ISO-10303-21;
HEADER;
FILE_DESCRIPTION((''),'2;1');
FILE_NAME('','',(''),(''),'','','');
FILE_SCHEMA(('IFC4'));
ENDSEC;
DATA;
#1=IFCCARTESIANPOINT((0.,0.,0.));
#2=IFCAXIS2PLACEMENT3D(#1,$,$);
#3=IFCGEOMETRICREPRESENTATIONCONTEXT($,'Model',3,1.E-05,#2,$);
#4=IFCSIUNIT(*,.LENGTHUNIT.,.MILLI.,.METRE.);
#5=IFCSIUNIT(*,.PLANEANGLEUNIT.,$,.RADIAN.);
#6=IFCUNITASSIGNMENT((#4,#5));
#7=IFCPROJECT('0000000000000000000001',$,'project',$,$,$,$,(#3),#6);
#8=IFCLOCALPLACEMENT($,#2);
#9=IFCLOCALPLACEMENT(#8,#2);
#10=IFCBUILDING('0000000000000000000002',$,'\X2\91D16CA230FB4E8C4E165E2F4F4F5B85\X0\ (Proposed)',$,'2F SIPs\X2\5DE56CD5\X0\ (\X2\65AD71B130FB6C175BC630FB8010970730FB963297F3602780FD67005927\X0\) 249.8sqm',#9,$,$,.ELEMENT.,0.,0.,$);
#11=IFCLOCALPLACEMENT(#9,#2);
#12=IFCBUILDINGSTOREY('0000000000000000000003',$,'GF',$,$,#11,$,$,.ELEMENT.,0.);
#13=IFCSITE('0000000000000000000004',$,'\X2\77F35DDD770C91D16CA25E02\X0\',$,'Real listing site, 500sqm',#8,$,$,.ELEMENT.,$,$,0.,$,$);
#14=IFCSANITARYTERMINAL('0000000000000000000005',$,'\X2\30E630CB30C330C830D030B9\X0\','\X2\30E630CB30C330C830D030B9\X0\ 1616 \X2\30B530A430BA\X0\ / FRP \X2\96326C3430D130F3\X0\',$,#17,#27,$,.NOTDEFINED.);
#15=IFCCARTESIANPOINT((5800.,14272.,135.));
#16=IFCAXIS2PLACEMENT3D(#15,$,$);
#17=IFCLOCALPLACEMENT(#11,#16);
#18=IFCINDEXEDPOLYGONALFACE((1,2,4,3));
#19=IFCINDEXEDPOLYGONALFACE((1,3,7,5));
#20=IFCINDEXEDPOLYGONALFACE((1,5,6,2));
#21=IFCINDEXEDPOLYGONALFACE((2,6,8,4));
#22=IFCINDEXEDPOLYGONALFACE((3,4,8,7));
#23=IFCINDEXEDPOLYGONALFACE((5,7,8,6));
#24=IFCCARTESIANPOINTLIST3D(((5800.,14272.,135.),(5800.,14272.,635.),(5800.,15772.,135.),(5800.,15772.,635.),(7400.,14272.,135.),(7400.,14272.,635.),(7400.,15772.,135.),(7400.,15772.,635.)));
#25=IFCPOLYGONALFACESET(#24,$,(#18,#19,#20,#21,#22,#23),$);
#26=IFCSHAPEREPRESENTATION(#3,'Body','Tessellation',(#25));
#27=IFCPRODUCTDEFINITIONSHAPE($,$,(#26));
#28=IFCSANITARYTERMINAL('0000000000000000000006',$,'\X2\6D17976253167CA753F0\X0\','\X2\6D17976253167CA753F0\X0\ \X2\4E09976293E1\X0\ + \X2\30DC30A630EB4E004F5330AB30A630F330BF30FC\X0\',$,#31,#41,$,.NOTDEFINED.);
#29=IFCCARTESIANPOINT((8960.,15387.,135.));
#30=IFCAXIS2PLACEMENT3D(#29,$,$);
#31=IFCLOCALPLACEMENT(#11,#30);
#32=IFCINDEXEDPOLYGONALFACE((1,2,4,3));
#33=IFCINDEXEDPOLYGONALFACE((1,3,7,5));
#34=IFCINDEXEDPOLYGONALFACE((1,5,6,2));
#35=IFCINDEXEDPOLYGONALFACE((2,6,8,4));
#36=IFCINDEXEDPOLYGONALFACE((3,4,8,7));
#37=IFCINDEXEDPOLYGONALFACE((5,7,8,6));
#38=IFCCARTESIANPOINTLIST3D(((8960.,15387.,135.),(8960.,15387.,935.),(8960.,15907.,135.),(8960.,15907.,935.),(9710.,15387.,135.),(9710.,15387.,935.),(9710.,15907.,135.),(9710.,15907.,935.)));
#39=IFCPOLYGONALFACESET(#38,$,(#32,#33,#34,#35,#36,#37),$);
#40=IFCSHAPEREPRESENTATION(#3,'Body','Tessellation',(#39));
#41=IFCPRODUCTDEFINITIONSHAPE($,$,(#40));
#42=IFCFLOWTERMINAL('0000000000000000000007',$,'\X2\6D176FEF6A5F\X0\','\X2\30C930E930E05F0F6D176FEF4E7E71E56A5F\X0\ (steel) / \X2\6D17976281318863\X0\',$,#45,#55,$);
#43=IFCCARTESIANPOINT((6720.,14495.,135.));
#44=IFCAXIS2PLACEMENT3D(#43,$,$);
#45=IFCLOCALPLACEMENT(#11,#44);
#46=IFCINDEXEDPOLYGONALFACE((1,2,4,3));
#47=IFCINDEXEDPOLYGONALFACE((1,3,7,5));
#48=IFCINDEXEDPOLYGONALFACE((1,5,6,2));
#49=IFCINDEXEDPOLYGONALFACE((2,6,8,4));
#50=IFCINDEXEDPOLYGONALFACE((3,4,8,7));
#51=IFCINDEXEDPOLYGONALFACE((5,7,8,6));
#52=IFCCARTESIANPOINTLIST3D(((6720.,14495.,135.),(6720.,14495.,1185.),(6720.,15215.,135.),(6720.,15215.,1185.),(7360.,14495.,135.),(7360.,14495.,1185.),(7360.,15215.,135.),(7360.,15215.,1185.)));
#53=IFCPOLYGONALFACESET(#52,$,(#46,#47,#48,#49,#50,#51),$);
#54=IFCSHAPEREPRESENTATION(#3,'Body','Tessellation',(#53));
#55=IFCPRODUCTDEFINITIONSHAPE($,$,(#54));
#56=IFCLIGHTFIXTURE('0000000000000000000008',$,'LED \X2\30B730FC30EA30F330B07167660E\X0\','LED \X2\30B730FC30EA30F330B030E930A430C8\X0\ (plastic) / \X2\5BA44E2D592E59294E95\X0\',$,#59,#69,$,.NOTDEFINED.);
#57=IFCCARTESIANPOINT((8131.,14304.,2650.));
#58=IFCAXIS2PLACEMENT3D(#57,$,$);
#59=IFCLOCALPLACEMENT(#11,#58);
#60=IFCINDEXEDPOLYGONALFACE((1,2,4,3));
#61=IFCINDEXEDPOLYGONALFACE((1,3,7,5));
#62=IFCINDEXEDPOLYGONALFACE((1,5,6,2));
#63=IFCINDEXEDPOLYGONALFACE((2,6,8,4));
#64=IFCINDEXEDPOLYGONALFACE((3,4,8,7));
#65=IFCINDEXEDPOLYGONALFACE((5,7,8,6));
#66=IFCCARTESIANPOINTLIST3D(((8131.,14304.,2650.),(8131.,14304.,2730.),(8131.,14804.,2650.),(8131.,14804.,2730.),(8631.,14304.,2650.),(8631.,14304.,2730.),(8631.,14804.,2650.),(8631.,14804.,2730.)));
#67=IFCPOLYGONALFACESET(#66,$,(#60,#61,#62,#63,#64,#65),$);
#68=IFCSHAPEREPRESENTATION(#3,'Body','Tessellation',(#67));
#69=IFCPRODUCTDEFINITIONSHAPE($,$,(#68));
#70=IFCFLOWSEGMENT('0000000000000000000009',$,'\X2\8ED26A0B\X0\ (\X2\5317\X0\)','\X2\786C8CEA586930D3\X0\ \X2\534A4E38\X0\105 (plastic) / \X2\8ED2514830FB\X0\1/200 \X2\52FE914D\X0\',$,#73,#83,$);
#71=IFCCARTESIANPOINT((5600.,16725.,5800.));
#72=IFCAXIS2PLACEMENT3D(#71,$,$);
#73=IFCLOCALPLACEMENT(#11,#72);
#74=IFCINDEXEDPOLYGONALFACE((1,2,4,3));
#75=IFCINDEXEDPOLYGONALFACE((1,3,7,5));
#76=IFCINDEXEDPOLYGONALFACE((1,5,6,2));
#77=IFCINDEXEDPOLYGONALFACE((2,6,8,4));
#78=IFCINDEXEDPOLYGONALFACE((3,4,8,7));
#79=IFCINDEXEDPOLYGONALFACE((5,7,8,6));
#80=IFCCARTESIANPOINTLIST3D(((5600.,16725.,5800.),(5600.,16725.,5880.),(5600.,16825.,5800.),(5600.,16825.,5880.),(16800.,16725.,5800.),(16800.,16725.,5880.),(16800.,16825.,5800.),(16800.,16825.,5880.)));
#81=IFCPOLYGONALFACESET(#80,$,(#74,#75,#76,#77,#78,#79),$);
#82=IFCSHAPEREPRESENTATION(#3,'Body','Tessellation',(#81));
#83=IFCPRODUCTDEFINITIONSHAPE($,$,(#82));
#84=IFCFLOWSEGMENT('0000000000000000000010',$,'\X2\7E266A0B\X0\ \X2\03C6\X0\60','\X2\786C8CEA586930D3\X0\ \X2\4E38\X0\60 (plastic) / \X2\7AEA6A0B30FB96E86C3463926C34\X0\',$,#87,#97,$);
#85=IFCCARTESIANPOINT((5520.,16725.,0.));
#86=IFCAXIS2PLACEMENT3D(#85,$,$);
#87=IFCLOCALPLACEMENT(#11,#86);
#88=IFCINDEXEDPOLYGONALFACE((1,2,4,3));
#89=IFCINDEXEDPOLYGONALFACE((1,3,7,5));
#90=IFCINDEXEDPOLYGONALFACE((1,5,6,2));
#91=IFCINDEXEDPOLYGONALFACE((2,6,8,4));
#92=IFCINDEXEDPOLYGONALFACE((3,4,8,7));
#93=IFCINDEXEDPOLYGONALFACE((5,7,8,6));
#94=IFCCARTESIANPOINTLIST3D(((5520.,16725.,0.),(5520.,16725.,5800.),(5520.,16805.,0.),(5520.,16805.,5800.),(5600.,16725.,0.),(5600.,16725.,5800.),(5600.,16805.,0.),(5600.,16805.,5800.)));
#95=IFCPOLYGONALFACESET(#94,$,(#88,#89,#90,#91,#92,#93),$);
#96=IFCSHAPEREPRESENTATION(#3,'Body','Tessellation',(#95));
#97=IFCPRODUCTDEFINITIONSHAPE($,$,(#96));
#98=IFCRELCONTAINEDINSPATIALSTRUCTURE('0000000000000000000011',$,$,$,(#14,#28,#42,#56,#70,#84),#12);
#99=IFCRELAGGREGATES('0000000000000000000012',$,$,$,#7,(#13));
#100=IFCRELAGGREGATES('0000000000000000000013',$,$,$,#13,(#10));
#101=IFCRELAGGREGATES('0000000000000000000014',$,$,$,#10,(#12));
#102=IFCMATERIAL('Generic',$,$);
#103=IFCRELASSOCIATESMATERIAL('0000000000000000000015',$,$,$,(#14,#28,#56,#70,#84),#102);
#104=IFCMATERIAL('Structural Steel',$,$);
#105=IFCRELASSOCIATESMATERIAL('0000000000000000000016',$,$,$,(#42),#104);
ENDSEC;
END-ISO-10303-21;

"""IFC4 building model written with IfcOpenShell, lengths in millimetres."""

from ifc_helpers import new_model, si_unit, frame, frame_2d, origin, place, context, project, spatial, rectangle, extrude, material, element, save


model = new_model("IFC4")

# Units and contexts
model_context = context("Model", 3, precision=1e-05, world=origin())
ifc_project = project(units=[si_unit("LENGTHUNIT", "METRE", prefix="MILLI"), si_unit("PLANEANGLEUNIT", "RADIAN")], contexts=[model_context])

# Site, building, storey
site_placement = place(None, origin())
site = spatial("IfcSite", under=ifc_project, at=site_placement, Name="石川県金沢市", ObjectType="Real listing site, 500sqm", CompositionType="ELEMENT", RefElevation=0.0)
building_placement = place(site_placement, origin())
building = spatial("IfcBuilding", under=site, at=building_placement, Name="金沢・二世帯住宅 (Proposed)", ObjectType="2F SIPs工法 (断熱・気密・耐震・防音性能最大) 249.8sqm", CompositionType="ELEMENT", ElevationOfRefHeight=0.0, ElevationOfTerrain=0.0)
storey_placement = place(building_placement, origin())
storey = spatial("IfcBuildingStorey", under=building, at=storey_placement, Name="GF", CompositionType="ELEMENT", Elevation=0.0)

# Sanitary terminals
ifc_material_1 = material(Name="Generic")
sanitary_terminal_1_placement = place(storey_placement, frame((5800.0, 14272.0, 135.0)))
element("IfcSanitaryTerminal", 1, at=sanitary_terminal_1_placement, inside=storey, material=ifc_material_1, Name="ユニットバス", Description="ユニットバス 1616 サイズ / FRP 防水パン", PredefinedType="NOTDEFINED", context=model_context, shape_type="SweptSolid", body=[
    extrude(rectangle(XDim=1600.0, YDim=1500.0, at=frame_2d((800.0, 750.0))), frame((5800.0, 14272.0, 135.0)), (0.0, 0.0, 1.0), 500.0),
])
sanitary_terminal_2_placement = place(storey_placement, frame((8960.0, 15387.0, 135.0)))
element("IfcSanitaryTerminal", 2, at=sanitary_terminal_2_placement, inside=storey, material=ifc_material_1, Name="洗面化粧台", Description="洗面化粧台 三面鏡 + ボウル一体カウンター", PredefinedType="NOTDEFINED", context=model_context, shape_type="SweptSolid", body=[
    extrude(rectangle(XDim=750.0, YDim=520.0, at=frame_2d((375.0, 260.0))), frame((8960.0, 15387.0, 135.0)), (0.0, 0.0, 1.0), 800.0),
])

# Flow terminal
ifc_material_2 = material(Name="Structural Steel")
flow_terminal_placement = place(storey_placement, frame((6720.0, 14495.0, 135.0)))
element("IfcFlowTerminal", 3, at=flow_terminal_placement, inside=storey, material=ifc_material_2, Name="洗濯機", Description="ドラム式洗濯乾燥機 (steel) / 洗面脱衣", context=model_context, shape_type="SweptSolid", body=[
    extrude(rectangle(XDim=640.0, YDim=720.0, at=frame_2d((320.0, 360.0))), frame((6720.0, 14495.0, 135.0)), (0.0, 0.0, 1.0), 1050.0),
])

# Light fixture
light_fixture_placement = place(storey_placement, frame((8131.0, 14304.0, 2650.0)))
element("IfcLightFixture", 4, at=light_fixture_placement, inside=storey, material=ifc_material_1, Name="LED シーリング照明", Description="LED シーリングライト (plastic) / 室中央天井", PredefinedType="NOTDEFINED", context=model_context, shape_type="SweptSolid", body=[
    extrude(rectangle(XDim=500.0, YDim=500.0, at=frame_2d((250.0, 250.0))), frame((8131.0, 14304.0, 2650.0)), (0.0, 0.0, 1.0), 80.0),
])

# Flow segments
flow_segment_1_placement = place(storey_placement, frame((5600.0, 16725.0, 5800.0)))
element("IfcFlowSegment", 5, at=flow_segment_1_placement, inside=storey, material=ifc_material_1, Name="軒樋 (北)", Description="硬質塩ビ 半丸105 (plastic) / 軒先・1/200 勾配", context=model_context, shape_type="SweptSolid", body=[
    extrude(rectangle(XDim=11200.0, YDim=100.0, at=frame_2d((5600.0, 50.0))), frame((5600.0, 16725.0, 5800.0)), (0.0, 0.0, 1.0), 80.0),
])
flow_segment_2_placement = place(storey_placement, frame((5520.0, 16725.0, 0.0)))
element("IfcFlowSegment", 6, at=flow_segment_2_placement, inside=storey, material=ifc_material_1, Name="縦樋 φ60", Description="硬質塩ビ 丸60 (plastic) / 竪樋・雨水排水", context=model_context, shape_type="SweptSolid", body=[
    extrude(rectangle(XDim=80.0, YDim=80.0, at=frame_2d((40.0, 40.0))), frame((5520.0, 16725.0, 0.0)), (0.0, 0.0, 1.0), 5800.0),
])

save(model, "model.ifc")
